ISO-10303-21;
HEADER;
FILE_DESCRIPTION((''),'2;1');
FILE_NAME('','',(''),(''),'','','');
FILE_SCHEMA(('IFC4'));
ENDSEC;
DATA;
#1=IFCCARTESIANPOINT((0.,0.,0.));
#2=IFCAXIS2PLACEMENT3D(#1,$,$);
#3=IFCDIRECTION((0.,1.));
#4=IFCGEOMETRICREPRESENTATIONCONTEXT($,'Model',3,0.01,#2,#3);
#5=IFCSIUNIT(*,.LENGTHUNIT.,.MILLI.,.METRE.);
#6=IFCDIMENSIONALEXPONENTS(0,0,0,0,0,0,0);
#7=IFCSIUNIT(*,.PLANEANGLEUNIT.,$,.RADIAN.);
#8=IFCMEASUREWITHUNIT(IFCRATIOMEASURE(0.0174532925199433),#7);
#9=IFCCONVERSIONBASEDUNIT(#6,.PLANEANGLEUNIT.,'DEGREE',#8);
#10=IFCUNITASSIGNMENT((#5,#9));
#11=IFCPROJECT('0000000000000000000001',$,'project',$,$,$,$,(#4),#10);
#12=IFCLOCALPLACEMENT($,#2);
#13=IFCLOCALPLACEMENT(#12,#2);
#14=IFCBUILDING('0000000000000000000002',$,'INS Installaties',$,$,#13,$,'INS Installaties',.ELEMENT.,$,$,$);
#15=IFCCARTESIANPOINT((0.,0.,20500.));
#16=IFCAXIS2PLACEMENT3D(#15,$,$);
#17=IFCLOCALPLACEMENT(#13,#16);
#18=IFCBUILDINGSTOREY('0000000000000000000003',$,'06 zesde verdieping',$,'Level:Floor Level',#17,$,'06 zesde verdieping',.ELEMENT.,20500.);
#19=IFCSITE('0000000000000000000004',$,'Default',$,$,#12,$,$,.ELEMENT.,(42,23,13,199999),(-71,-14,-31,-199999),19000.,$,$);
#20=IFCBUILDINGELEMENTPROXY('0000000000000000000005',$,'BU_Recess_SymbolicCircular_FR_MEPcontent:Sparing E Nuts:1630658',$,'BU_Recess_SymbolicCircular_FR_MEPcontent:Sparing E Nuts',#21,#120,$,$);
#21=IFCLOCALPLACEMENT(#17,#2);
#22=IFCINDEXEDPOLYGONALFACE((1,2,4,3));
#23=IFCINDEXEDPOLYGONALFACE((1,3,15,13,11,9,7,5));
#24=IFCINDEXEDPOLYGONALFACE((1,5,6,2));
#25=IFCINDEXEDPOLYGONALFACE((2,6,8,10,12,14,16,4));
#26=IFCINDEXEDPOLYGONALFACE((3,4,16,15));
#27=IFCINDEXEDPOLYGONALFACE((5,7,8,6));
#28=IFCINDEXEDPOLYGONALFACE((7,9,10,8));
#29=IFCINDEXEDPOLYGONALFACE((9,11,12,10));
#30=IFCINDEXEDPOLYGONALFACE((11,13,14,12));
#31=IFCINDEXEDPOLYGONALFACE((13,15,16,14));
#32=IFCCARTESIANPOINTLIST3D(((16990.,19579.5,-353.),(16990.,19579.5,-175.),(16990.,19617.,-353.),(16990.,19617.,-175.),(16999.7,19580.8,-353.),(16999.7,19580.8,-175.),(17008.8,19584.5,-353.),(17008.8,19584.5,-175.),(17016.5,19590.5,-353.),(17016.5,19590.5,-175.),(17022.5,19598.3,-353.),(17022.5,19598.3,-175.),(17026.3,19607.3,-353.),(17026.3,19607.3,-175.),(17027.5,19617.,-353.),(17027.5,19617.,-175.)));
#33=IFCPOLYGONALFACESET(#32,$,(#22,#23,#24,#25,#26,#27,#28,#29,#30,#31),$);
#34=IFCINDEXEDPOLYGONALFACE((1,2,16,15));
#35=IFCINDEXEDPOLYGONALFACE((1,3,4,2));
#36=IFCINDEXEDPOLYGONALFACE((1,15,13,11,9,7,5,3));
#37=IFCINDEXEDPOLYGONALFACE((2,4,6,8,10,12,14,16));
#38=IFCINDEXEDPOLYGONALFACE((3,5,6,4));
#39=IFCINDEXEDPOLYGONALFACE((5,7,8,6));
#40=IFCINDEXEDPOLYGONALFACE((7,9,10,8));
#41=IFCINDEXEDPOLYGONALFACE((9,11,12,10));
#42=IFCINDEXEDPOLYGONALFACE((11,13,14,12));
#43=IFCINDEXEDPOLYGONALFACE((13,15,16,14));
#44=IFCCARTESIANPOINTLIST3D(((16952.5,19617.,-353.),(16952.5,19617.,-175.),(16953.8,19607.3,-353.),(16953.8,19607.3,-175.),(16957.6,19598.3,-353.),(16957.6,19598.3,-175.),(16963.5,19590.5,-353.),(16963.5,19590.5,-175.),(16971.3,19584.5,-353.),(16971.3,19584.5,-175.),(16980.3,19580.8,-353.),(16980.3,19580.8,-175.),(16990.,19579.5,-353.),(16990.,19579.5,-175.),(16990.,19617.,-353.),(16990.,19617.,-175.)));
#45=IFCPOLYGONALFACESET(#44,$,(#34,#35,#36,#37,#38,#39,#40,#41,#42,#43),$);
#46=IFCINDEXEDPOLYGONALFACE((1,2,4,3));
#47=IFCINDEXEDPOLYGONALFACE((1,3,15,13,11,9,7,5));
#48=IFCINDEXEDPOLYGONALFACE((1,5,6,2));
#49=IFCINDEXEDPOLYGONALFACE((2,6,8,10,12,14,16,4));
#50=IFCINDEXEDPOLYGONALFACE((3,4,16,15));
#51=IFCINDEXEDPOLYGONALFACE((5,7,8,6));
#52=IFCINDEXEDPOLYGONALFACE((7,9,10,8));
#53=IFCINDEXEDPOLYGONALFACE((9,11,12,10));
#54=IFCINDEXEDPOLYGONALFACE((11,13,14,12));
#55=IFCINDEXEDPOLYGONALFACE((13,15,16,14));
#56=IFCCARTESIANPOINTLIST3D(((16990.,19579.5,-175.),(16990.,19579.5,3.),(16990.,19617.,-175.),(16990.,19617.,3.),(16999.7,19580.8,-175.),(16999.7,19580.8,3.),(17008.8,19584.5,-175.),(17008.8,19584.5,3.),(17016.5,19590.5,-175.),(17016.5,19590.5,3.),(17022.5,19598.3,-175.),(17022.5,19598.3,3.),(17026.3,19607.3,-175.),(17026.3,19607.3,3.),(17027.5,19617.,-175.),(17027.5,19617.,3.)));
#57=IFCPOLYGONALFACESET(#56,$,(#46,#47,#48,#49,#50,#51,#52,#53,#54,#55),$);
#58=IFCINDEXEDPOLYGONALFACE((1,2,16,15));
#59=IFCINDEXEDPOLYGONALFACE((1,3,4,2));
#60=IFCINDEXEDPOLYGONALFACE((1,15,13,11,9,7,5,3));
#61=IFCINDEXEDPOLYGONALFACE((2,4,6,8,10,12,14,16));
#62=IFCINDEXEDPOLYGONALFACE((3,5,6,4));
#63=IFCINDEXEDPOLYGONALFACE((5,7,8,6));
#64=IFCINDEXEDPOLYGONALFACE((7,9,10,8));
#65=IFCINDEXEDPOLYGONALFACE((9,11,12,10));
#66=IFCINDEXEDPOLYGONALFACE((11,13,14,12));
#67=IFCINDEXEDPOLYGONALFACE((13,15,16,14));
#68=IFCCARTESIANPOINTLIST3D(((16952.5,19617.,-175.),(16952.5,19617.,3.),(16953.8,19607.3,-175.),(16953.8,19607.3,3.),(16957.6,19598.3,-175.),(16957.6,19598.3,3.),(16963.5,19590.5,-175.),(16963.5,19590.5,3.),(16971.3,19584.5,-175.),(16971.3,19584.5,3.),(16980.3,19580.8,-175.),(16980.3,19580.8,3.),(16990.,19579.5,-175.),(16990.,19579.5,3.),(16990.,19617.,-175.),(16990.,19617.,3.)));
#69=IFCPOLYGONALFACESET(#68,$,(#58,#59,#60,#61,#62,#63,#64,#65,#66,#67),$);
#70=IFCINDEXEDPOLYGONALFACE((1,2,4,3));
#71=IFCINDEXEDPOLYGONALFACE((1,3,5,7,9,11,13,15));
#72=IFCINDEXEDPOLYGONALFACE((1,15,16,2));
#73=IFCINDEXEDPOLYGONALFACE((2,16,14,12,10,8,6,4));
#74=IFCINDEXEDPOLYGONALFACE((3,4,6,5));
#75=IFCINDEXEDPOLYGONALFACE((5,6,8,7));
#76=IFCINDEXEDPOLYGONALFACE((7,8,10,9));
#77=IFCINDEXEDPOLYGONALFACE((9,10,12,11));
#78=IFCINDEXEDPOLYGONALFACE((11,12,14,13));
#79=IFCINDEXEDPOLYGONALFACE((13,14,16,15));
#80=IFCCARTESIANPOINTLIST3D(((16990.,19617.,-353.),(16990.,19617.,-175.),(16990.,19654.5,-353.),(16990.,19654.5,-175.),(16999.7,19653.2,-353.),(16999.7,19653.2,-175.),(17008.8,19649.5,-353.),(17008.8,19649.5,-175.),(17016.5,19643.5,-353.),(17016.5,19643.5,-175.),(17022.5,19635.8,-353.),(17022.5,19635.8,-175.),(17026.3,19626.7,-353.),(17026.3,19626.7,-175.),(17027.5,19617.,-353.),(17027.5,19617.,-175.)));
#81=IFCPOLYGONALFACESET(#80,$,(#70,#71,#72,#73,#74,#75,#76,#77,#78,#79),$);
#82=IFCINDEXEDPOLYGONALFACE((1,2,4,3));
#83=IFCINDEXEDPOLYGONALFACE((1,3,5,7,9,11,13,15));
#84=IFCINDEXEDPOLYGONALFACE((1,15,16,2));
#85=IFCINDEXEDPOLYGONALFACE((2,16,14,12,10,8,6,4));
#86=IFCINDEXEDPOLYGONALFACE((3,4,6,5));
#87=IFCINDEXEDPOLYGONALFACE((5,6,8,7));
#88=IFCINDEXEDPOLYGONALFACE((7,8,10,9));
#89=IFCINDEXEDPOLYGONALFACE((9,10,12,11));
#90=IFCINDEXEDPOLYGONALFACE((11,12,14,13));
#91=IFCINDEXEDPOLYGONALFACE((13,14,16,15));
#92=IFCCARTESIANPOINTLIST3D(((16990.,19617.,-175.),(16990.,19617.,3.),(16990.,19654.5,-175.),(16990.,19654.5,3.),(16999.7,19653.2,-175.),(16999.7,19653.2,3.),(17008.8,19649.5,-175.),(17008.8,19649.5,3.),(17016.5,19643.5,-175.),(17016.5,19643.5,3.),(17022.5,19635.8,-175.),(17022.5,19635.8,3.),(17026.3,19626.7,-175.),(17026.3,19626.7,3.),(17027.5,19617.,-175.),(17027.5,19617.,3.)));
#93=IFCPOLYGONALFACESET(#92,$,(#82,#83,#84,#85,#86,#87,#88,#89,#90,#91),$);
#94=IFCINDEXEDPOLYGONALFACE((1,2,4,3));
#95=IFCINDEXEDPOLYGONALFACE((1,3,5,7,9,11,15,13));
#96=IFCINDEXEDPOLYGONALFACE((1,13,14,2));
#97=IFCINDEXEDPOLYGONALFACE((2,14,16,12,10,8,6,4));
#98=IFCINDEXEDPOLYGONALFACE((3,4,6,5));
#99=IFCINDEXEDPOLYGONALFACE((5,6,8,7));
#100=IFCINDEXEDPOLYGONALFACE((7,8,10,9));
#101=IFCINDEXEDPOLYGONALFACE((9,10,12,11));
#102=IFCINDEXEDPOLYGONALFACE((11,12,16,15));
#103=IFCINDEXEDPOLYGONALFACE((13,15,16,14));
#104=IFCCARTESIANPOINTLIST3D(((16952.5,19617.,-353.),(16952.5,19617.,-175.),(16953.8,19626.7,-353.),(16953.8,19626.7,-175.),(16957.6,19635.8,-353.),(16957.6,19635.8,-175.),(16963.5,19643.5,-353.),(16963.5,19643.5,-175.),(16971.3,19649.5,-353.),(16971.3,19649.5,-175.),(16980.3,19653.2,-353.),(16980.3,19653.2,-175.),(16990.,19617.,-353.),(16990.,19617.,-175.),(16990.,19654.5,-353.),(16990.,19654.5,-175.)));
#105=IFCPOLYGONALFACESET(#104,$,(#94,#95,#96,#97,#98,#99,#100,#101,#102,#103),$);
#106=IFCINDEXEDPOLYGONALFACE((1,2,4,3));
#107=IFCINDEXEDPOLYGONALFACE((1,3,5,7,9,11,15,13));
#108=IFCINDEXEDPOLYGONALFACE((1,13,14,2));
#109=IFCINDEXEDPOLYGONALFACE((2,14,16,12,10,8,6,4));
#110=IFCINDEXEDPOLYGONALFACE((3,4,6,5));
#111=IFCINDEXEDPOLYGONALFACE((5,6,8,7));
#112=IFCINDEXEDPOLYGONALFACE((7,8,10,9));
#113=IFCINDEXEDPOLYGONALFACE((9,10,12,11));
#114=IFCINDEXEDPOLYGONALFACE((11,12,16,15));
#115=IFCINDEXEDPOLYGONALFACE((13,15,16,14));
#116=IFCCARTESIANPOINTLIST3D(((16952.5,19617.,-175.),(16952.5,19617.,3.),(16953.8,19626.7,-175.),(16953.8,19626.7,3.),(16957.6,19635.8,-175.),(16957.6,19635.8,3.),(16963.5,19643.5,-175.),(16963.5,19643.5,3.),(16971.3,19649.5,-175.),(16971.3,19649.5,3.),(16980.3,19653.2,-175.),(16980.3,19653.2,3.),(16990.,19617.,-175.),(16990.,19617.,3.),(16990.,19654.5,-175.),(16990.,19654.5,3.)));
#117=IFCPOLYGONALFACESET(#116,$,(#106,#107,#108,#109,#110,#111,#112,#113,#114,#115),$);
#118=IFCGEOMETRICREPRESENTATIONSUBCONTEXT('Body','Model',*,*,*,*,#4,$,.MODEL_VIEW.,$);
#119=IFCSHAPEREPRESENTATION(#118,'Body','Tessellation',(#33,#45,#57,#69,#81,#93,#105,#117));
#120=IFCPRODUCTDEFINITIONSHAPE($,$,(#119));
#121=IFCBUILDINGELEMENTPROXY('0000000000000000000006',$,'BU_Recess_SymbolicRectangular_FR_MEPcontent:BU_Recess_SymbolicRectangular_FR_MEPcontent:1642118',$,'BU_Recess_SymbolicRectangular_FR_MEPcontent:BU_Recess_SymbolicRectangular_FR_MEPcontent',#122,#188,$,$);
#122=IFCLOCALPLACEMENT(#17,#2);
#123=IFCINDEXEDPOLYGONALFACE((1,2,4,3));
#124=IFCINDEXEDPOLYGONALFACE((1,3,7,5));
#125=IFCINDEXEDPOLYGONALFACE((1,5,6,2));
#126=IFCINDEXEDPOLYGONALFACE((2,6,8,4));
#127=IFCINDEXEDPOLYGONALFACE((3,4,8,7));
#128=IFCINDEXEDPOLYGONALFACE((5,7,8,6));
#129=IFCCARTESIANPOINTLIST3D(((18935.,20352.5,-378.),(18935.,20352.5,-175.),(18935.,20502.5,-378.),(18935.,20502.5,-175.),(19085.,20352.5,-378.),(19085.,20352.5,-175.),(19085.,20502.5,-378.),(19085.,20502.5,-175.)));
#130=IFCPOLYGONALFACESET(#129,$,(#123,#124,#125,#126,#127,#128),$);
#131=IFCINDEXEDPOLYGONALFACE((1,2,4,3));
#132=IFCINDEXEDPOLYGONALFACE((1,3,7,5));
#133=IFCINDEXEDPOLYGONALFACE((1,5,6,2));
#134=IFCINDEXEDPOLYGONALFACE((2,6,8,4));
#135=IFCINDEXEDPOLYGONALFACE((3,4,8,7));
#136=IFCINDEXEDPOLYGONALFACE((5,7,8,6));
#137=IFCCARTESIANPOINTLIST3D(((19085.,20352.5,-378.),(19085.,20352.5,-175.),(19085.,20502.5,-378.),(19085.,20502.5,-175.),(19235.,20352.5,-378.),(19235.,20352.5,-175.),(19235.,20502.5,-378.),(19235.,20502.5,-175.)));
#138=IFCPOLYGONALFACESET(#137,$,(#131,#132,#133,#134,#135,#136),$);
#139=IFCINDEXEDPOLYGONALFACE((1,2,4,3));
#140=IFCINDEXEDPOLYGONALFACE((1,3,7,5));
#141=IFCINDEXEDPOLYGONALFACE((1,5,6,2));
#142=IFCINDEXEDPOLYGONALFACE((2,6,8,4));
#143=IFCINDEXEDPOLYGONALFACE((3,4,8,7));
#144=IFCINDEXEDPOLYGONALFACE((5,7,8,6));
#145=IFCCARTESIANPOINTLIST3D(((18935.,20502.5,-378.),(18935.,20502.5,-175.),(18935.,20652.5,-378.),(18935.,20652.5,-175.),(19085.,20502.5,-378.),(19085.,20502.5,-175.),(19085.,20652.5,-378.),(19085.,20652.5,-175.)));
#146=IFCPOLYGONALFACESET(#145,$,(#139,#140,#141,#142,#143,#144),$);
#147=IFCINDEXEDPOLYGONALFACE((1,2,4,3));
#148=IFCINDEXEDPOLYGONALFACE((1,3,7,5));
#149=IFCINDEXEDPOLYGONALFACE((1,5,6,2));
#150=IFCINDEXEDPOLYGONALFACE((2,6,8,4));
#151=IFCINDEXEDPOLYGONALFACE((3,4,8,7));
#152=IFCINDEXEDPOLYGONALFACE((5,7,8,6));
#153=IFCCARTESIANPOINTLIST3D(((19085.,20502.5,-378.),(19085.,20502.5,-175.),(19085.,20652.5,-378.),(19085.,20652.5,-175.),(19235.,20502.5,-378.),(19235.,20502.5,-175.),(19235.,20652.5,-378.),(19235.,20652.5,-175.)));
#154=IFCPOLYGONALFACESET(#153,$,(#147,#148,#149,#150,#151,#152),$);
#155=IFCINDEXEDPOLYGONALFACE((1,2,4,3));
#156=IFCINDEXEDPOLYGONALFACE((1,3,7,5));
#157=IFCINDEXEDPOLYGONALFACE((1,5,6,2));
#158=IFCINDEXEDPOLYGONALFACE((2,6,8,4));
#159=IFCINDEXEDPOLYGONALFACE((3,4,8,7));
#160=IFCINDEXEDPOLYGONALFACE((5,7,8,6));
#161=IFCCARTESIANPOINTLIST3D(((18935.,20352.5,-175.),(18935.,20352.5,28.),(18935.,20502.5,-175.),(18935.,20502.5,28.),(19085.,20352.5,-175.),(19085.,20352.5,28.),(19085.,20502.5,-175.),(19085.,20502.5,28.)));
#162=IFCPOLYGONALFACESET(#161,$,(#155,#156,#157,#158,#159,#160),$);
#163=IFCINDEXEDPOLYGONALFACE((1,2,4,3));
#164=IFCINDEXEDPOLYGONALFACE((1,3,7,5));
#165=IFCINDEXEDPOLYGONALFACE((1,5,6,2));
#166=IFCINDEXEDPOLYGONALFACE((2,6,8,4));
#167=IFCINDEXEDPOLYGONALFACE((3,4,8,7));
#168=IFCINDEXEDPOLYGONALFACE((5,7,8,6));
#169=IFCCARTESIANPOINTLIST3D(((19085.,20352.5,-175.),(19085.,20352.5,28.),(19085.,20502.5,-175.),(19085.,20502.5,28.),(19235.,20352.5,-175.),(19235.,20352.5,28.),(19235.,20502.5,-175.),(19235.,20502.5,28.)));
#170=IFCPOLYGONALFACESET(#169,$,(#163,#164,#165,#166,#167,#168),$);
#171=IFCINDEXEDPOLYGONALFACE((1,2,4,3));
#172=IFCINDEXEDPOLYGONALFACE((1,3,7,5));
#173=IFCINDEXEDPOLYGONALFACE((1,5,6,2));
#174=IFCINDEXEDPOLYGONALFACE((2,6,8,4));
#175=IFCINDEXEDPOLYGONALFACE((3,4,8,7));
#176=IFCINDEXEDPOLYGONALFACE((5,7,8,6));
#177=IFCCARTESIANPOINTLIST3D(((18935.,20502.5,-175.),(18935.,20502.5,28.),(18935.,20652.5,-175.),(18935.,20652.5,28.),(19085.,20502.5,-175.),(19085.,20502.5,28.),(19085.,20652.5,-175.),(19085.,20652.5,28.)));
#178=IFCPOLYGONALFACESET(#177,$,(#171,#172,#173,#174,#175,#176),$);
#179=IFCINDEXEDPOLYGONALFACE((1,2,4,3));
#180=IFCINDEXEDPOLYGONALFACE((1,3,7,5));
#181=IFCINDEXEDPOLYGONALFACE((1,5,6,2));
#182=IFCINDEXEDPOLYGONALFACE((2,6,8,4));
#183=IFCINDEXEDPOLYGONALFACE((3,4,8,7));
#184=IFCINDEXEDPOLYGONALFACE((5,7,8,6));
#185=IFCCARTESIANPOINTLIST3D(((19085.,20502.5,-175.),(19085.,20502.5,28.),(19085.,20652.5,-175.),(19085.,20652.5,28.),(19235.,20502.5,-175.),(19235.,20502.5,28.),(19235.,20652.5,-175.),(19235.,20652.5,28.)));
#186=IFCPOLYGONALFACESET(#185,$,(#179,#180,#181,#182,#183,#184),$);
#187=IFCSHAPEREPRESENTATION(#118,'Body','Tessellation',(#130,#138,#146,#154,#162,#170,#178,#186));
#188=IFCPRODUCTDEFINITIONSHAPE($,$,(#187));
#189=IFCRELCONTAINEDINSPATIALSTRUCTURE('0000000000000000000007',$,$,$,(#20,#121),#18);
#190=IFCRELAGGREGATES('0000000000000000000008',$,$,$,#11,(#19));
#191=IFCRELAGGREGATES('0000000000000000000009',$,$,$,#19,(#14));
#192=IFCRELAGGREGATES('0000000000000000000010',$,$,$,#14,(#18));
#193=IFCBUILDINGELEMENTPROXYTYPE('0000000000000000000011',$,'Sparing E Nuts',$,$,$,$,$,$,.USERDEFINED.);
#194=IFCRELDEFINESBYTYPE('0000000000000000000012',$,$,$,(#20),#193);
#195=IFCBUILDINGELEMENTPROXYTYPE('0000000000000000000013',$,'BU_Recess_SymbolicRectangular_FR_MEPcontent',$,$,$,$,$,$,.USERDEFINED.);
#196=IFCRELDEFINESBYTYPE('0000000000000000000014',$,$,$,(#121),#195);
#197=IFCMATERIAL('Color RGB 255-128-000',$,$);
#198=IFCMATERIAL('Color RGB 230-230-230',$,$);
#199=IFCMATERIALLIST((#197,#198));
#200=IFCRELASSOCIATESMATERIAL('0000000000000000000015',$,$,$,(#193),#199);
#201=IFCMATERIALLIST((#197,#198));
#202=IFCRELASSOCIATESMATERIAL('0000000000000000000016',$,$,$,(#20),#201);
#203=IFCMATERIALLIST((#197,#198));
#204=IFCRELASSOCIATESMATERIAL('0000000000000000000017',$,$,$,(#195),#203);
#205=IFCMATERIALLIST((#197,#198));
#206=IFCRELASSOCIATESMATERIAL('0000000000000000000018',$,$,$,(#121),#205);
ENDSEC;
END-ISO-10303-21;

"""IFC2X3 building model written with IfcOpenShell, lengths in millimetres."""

from ifc_helpers import new_model, entity, si_unit, converted_unit, direction, frame, frame_2d, origin, origin_2d_with_axis, place, context, subcontext, project, spatial, polyline, circle_curve, parameter, trimmed, segment, composite_curve, rectangle, outline, extrude, source, transform, mapped, material, material_list, type_object, type_shapes, element, save


model = new_model("IFC2X3")

# Units and contexts
model_context = context("Model", 3, precision=0.01, world=origin(), true_north=direction((0.0, 1.0)))
body_context = subcontext(model_context, "Body", "Model", "MODEL_VIEW")
ifc_project = project(units=[si_unit("LENGTHUNIT", "METRE", prefix="MILLI"), converted_unit("PLANEANGLEUNIT", "DEGREE", entity("IfcRatioMeasure", 0.0174532925199433), si_unit("PLANEANGLEUNIT", "RADIAN"), dimensions=[0, 0, 0, 0, 0, 0, 0])], contexts=[model_context])

# Site, building, storey
site_placement = place(None, origin())
site = spatial("IfcSite", under=ifc_project, at=site_placement, Name="Default", CompositionType="ELEMENT", RefLatitude=(42, 23, 13, 199999), RefLongitude=(-71, -14, -31, -199999), RefElevation=19000.0)
building_placement = place(site_placement, origin())
building = spatial("IfcBuilding", under=site, at=building_placement, Name="INS Installaties", LongName="INS Installaties", CompositionType="ELEMENT")
storey_placement = place(building_placement, frame((0.0, 0.0, 20500.0)))
storey = spatial("IfcBuildingStorey", under=building, at=storey_placement, Name="06 zesde verdieping", ObjectType="Level:Floor Level", LongName="06 zesde verdieping", CompositionType="ELEMENT", Elevation=20500.0)

# Building element proxies
ifc_material_1 = material(Name="Color RGB 255-128-000")
ifc_material_2 = material(Name="Color RGB 230-230-230")
ifc_material_list_1 = material_list([ifc_material_1, ifc_material_2])
building_element_proxy_type_1 = type_object("IfcBuildingElementProxyType", Name="Sparing E Nuts", PredefinedType="USERDEFINED", material=ifc_material_list_1)
shared_shape_1 = source(origin(), body_context, "Body", "SweptSolid", [
    extrude(outline(composite_curve([segment(polyline([(-25.0, -12.5), (12.5, -12.5)]), True, "CONTINUOUS"), segment(polyline([(12.5, -12.5), (12.5, 25.0)]), True, "CONTINUOUS"), segment(trimmed(circle_curve(frame_2d((12.5, -12.5), x_axis=(1.0, 0.0)), 37.5), [parameter(90.0)], [parameter(180.0)], True, "PARAMETER"), True, "CONTINUOUS")], self_intersect=False)), frame((12.5, -12.5, -353.0), z_axis=(0.0, 0.0, 1.0), x_axis=(-1.0, 0.0, 0.0)), (0.0, 0.0, 1.0), 178.0),
    extrude(outline(composite_curve([segment(trimmed(circle_curve(frame_2d((12.5, 12.5), x_axis=(1.0, 0.0)), 37.5), [parameter(180.0)], [parameter(270.0)], True, "PARAMETER"), True, "CONTINUOUS"), segment(polyline([(12.5, -25.0), (12.5, 12.5)]), True, "CONTINUOUS"), segment(polyline([(12.5, 12.5), (-25.0, 12.5)]), True, "CONTINUOUS")], self_intersect=False)), frame((-12.5, -12.5, -353.0)), (0.0, 0.0, 1.0), 178.0),
    extrude(outline(composite_curve([segment(polyline([(-25.0, -12.5), (12.5, -12.5)]), True, "CONTINUOUS"), segment(polyline([(12.5, -12.5), (12.5, 25.0)]), True, "CONTINUOUS"), segment(trimmed(circle_curve(frame_2d((12.5, -12.5), x_axis=(1.0, 0.0)), 37.5), [parameter(90.0)], [parameter(180.0)], True, "PARAMETER"), True, "CONTINUOUS")], self_intersect=False)), frame((12.5, -12.5, -175.0), z_axis=(0.0, 0.0, 1.0), x_axis=(-1.0, 0.0, 0.0)), (0.0, 0.0, 1.0), 178.0),
    extrude(outline(composite_curve([segment(trimmed(circle_curve(frame_2d((12.5, 12.5), x_axis=(1.0, 0.0)), 37.5), [parameter(180.0)], [parameter(270.0)], True, "PARAMETER"), True, "CONTINUOUS"), segment(polyline([(12.5, -25.0), (12.5, 12.5)]), True, "CONTINUOUS"), segment(polyline([(12.5, 12.5), (-25.0, 12.5)]), True, "CONTINUOUS")], self_intersect=False)), frame((-12.5, -12.5, -175.0)), (0.0, 0.0, 1.0), 178.0),
    extrude(outline(composite_curve([segment(trimmed(circle_curve(frame_2d((12.5, 12.5), x_axis=(1.0, 0.0)), 37.5), [parameter(180.0)], [parameter(270.0)], True, "PARAMETER"), True, "CONTINUOUS"), segment(polyline([(12.5, -25.0), (12.5, 12.5)]), True, "CONTINUOUS"), segment(polyline([(12.5, 12.5), (-25.0, 12.5)]), True, "CONTINUOUS")], self_intersect=False)), frame((12.5, 12.5, -353.0), z_axis=(0.0, 0.0, 1.0), x_axis=(-1.0, 0.0, 0.0)), (0.0, 0.0, 1.0), 178.0),
    extrude(outline(composite_curve([segment(trimmed(circle_curve(frame_2d((12.5, 12.5), x_axis=(1.0, 0.0)), 37.5), [parameter(180.0)], [parameter(270.0)], True, "PARAMETER"), True, "CONTINUOUS"), segment(polyline([(12.5, -25.0), (12.5, 12.5)]), True, "CONTINUOUS"), segment(polyline([(12.5, 12.5), (-25.0, 12.5)]), True, "CONTINUOUS")], self_intersect=False)), frame((12.5, 12.5, -175.0), z_axis=(0.0, 0.0, 1.0), x_axis=(-1.0, 0.0, 0.0)), (0.0, 0.0, 1.0), 178.0),
    extrude(outline(composite_curve([segment(polyline([(-25.0, -12.5), (12.5, -12.5)]), True, "CONTINUOUS"), segment(polyline([(12.5, -12.5), (12.5, 25.0)]), True, "CONTINUOUS"), segment(trimmed(circle_curve(frame_2d((12.5, -12.5), x_axis=(1.0, 0.0)), 37.5), [parameter(90.0)], [parameter(180.0)], True, "PARAMETER"), True, "CONTINUOUS")], self_intersect=False)), frame((-12.5, 12.5, -353.0)), (0.0, 0.0, 1.0), 178.0),
    extrude(outline(composite_curve([segment(polyline([(-25.0, -12.5), (12.5, -12.5)]), True, "CONTINUOUS"), segment(polyline([(12.5, -12.5), (12.5, 25.0)]), True, "CONTINUOUS"), segment(trimmed(circle_curve(frame_2d((12.5, -12.5), x_axis=(1.0, 0.0)), 37.5), [parameter(90.0)], [parameter(180.0)], True, "PARAMETER"), True, "CONTINUOUS")], self_intersect=False)), frame((-12.5, 12.5, -175.0)), (0.0, 0.0, 1.0), 178.0),
])
type_shapes(building_element_proxy_type_1, [shared_shape_1])
ifc_material_list_2 = material_list([ifc_material_1, ifc_material_2])
proxy_1_placement = place(storey_placement, frame((16990.0, 19617.0, 0.0)))
element("IfcBuildingElementProxy", 1, at=proxy_1_placement, inside=storey, type_object=building_element_proxy_type_1, material=ifc_material_list_2, Name="BU_Recess_SymbolicCircular_FR_MEPcontent:Sparing E Nuts:1630658", ObjectType="BU_Recess_SymbolicCircular_FR_MEPcontent:Sparing E Nuts", context=body_context, shape_type="MappedRepresentation", body=[
    mapped(shared_shape_1, transform((0.0, 0.0, 0.0), scale=1.0)),
])
ifc_material_list_3 = material_list([ifc_material_1, ifc_material_2])
ifc_material_list_4 = material_list([ifc_material_1, ifc_material_2])
building_element_proxy_type_2 = type_object("IfcBuildingElementProxyType", Name="BU_Recess_SymbolicRectangular_FR_MEPcontent", PredefinedType="USERDEFINED", material=ifc_material_list_4)
shared_shape_2 = source(origin(), body_context, "Body", "SweptSolid", [
    extrude(rectangle(XDim=150.0, YDim=150.0, at=origin_2d_with_axis()), frame((75.0, 75.0, -403.0), z_axis=(0.0, 0.0, 1.0), x_axis=(0.0, -1.0, 0.0)), (0.0, 0.0, 1.0), 203.0),
    extrude(rectangle(XDim=150.0, YDim=150.0, at=frame_2d((0.0, 0.0), x_axis=(1.0, 0.0))), frame((-75.0, 75.0, -403.0), z_axis=(0.0, 0.0, 1.0), x_axis=(-1.0, 0.0, 0.0)), (0.0, 0.0, 1.0), 203.0),
    extrude(rectangle(XDim=150.0, YDim=150.0, at=frame_2d((0.0, 0.0), x_axis=(1.0, 0.0))), frame((75.0, -75.0, -403.0)), (0.0, 0.0, 1.0), 203.0),
    extrude(rectangle(XDim=150.0, YDim=150.0, at=origin_2d_with_axis()), frame((-75.0, -75.0, -403.0), z_axis=(0.0, 0.0, 1.0), x_axis=(0.0, 1.0, 0.0)), (0.0, 0.0, 1.0), 203.0),
    extrude(rectangle(XDim=150.0, YDim=150.0, at=origin_2d_with_axis()), frame((75.0, 75.0, -200.0), z_axis=(0.0, 0.0, 1.0), x_axis=(0.0, -1.0, 0.0)), (0.0, 0.0, 1.0), 203.0),
    extrude(rectangle(XDim=150.0, YDim=150.0, at=frame_2d((0.0, 0.0), x_axis=(1.0, 0.0))), frame((-75.0, 75.0, -200.0), z_axis=(0.0, 0.0, 1.0), x_axis=(-1.0, 0.0, 0.0)), (0.0, 0.0, 1.0), 203.0),
    extrude(rectangle(XDim=150.0, YDim=150.0, at=frame_2d((0.0, 0.0), x_axis=(1.0, 0.0))), frame((75.0, -75.0, -200.0)), (0.0, 0.0, 1.0), 203.0),
    extrude(rectangle(XDim=150.0, YDim=150.0, at=origin_2d_with_axis()), frame((-75.0, -75.0, -200.0), z_axis=(0.0, 0.0, 1.0), x_axis=(0.0, 1.0, 0.0)), (0.0, 0.0, 1.0), 203.0),
])
type_shapes(building_element_proxy_type_2, [shared_shape_2])
proxy_2_placement = place(storey_placement, frame((19085.0, 20502.5, 25.0), z_axis=(0.0, 0.0, 1.0), x_axis=(-1.0, 0.0, 0.0)))
element("IfcBuildingElementProxy", 2, at=proxy_2_placement, inside=storey, type_object=building_element_proxy_type_2, material=ifc_material_list_3, Name="BU_Recess_SymbolicRectangular_FR_MEPcontent:BU_Recess_SymbolicRectangular_FR_MEPcontent:1642118", ObjectType="BU_Recess_SymbolicRectangular_FR_MEPcontent:BU_Recess_SymbolicRectangular_FR_MEPcontent", context=body_context, shape_type="MappedRepresentation", body=[
    mapped(shared_shape_2, transform((0.0, 0.0, 0.0), scale=1.0)),
])

save(model, "model.ifc")
